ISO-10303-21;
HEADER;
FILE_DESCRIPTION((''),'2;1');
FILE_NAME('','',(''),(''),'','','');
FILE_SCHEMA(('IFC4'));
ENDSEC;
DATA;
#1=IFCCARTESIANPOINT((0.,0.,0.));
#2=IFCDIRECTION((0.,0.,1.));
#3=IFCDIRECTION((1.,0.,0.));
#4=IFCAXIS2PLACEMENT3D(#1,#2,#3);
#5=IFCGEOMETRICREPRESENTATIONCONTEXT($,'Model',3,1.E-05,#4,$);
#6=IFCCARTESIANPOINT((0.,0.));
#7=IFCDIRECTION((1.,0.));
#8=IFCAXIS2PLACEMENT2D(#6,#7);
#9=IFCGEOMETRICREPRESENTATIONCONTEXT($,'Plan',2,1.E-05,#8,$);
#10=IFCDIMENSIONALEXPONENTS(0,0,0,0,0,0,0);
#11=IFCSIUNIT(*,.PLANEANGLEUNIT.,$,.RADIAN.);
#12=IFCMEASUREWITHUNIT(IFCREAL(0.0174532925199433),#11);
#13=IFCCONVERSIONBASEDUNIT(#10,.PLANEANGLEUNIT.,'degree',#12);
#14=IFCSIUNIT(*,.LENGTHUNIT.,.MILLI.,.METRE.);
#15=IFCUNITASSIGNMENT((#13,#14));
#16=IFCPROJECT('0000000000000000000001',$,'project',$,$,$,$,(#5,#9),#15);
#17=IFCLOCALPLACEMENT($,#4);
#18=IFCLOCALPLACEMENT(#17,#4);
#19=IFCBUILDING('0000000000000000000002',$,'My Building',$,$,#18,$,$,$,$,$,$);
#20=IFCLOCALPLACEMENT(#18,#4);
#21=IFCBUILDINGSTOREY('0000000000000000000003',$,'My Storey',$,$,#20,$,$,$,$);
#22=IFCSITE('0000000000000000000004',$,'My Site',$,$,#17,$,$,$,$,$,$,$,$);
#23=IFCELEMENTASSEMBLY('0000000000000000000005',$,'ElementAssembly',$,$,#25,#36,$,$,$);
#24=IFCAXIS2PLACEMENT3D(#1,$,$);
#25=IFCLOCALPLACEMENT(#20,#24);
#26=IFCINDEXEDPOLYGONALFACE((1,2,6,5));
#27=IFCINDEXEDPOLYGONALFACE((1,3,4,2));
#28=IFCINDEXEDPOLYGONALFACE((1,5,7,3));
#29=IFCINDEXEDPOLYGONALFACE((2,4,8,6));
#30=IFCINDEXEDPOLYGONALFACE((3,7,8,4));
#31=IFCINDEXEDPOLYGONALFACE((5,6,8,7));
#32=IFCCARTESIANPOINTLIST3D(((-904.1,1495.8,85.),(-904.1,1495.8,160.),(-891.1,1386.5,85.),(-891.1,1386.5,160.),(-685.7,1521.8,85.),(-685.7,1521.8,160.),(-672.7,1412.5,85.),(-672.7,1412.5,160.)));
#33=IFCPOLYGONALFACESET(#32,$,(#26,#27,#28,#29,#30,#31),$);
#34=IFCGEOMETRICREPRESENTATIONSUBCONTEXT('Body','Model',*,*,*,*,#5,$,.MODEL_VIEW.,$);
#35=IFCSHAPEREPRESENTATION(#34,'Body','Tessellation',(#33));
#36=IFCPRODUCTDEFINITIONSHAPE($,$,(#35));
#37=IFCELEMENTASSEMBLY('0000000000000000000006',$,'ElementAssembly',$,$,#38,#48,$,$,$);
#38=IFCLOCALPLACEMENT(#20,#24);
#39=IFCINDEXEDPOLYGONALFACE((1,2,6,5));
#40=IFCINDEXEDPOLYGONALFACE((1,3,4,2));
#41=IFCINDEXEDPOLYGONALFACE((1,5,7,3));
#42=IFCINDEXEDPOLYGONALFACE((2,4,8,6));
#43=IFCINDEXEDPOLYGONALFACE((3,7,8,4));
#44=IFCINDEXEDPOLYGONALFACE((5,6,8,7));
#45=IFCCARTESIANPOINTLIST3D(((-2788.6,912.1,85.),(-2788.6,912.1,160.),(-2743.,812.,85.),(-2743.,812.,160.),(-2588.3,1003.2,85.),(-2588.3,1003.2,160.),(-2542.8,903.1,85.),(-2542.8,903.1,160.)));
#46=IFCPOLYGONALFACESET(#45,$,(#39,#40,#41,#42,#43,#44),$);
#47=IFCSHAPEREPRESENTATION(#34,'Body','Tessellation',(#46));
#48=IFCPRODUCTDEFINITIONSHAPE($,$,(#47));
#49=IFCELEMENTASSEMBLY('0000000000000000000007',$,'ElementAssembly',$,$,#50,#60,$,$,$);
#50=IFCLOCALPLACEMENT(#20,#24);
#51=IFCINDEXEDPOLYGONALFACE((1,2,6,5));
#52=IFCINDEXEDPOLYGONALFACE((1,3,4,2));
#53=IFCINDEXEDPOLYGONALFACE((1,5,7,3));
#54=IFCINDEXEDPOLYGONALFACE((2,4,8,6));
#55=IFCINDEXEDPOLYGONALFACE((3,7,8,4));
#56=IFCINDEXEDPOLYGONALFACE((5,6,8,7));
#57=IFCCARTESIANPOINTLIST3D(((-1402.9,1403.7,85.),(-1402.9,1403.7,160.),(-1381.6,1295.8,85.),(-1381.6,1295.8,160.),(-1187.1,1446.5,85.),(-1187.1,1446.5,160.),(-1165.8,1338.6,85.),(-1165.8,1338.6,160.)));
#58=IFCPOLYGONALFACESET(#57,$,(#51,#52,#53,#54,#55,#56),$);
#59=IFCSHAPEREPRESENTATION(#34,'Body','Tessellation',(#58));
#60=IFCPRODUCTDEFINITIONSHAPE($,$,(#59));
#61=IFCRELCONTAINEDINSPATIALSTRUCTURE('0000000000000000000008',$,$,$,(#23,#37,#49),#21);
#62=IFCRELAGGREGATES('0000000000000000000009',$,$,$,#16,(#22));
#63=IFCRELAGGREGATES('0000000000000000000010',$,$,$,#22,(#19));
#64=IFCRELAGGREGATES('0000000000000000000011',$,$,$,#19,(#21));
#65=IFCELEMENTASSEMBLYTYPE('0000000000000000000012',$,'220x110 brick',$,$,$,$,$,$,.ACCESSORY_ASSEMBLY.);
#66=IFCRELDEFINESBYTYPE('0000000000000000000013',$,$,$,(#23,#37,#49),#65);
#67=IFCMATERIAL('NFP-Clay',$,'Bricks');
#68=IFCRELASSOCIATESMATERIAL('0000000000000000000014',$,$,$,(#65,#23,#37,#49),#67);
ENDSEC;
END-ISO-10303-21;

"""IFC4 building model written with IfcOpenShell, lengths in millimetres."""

from ifc_helpers import new_model, entity, si_unit, converted_unit, frame, origin_with_axes, origin_2d_with_axis, place, context, subcontext, project, spatial, rectangle, extrude, material, material_profile, profile_set, profile_usage, type_object, element, save


model = new_model("IFC4")

# Units and contexts
model_context = context("Model", 3, precision=1e-05, world=origin_with_axes())
plan_context = context("Plan", 2, precision=1e-05, world=origin_2d_with_axis())
body_context = subcontext(model_context, "Body", "Model", "MODEL_VIEW")
ifc_project = project(units=[converted_unit("PLANEANGLEUNIT", "degree", entity("IfcReal", 0.0174532925199433), si_unit("PLANEANGLEUNIT", "RADIAN"), dimensions=[0, 0, 0, 0, 0, 0, 0]), si_unit("LENGTHUNIT", "METRE", prefix="MILLI")], contexts=[model_context, plan_context])

# Site, building, storey
site_placement = place(None, origin_with_axes())
site = spatial("IfcSite", under=ifc_project, at=site_placement, Name="My Site")
building_placement = place(site_placement, origin_with_axes())
building = spatial("IfcBuilding", under=site, at=building_placement, Name="My Building")
storey_placement = place(building_placement, origin_with_axes())
storey = spatial("IfcBuildingStorey", under=building, at=storey_placement, Name="My Storey")

# Element assemblies
ifc_material = material(Name="NFP-Clay", Category="Bricks")
ifc_material_profile = material_profile(ifc_material, rectangle(XDim=220.0, YDim=110.0))
ifc_profile_set = profile_set([ifc_material_profile])
element_assembly_type = type_object("IfcElementAssemblyType", Name="220x110 brick", PredefinedType="ACCESSORY_ASSEMBLY", material=ifc_profile_set)
ifc_profile_usage_1 = profile_usage(ifc_profile_set, cardinal=5)
assembly_1_placement = place(storey_placement, frame((-788.4, 1454.2, 85.0), z_axis=(0.0, 0.0, 1.0), x_axis=(0.993003, 0.118089, 0.0)))
element("IfcElementAssembly", 1, at=assembly_1_placement, inside=storey, type_object=element_assembly_type, material=ifc_profile_usage_1, Name="ElementAssembly", context=body_context, shape_type="SweptSolid", body=[
    extrude(rectangle(XDim=220.0, YDim=110.0), origin_with_axes(), (0.0, 0.0, 1.0), 75.0),
])
ifc_profile_usage_2 = profile_usage(ifc_profile_set, cardinal=5)
assembly_2_placement = place(storey_placement, frame((-2665.7, 907.6, 85.0), z_axis=(0.0, 0.0, 1.0), x_axis=(0.910325, 0.413893, 0.0)))
element("IfcElementAssembly", 2, at=assembly_2_placement, inside=storey, type_object=element_assembly_type, material=ifc_profile_usage_2, Name="ElementAssembly", context=body_context, shape_type="SweptSolid", body=[
    extrude(rectangle(XDim=220.0, YDim=110.0), origin_with_axes(), (0.0, 0.0, 1.0), 75.0),
])
ifc_profile_usage_3 = profile_usage(ifc_profile_set, cardinal=5)
assembly_3_placement = place(storey_placement, frame((-1284.4, 1371.1, 85.0), z_axis=(0.0, 0.0, 1.0), x_axis=(0.980919, 0.194415, 0.0)))
element("IfcElementAssembly", 3, at=assembly_3_placement, inside=storey, type_object=element_assembly_type, material=ifc_profile_usage_3, Name="ElementAssembly", context=body_context, shape_type="SweptSolid", body=[
    extrude(rectangle(XDim=220.0, YDim=110.0), origin_with_axes(), (0.0, 0.0, 1.0), 75.0),
])

save(model, "model.ifc")
